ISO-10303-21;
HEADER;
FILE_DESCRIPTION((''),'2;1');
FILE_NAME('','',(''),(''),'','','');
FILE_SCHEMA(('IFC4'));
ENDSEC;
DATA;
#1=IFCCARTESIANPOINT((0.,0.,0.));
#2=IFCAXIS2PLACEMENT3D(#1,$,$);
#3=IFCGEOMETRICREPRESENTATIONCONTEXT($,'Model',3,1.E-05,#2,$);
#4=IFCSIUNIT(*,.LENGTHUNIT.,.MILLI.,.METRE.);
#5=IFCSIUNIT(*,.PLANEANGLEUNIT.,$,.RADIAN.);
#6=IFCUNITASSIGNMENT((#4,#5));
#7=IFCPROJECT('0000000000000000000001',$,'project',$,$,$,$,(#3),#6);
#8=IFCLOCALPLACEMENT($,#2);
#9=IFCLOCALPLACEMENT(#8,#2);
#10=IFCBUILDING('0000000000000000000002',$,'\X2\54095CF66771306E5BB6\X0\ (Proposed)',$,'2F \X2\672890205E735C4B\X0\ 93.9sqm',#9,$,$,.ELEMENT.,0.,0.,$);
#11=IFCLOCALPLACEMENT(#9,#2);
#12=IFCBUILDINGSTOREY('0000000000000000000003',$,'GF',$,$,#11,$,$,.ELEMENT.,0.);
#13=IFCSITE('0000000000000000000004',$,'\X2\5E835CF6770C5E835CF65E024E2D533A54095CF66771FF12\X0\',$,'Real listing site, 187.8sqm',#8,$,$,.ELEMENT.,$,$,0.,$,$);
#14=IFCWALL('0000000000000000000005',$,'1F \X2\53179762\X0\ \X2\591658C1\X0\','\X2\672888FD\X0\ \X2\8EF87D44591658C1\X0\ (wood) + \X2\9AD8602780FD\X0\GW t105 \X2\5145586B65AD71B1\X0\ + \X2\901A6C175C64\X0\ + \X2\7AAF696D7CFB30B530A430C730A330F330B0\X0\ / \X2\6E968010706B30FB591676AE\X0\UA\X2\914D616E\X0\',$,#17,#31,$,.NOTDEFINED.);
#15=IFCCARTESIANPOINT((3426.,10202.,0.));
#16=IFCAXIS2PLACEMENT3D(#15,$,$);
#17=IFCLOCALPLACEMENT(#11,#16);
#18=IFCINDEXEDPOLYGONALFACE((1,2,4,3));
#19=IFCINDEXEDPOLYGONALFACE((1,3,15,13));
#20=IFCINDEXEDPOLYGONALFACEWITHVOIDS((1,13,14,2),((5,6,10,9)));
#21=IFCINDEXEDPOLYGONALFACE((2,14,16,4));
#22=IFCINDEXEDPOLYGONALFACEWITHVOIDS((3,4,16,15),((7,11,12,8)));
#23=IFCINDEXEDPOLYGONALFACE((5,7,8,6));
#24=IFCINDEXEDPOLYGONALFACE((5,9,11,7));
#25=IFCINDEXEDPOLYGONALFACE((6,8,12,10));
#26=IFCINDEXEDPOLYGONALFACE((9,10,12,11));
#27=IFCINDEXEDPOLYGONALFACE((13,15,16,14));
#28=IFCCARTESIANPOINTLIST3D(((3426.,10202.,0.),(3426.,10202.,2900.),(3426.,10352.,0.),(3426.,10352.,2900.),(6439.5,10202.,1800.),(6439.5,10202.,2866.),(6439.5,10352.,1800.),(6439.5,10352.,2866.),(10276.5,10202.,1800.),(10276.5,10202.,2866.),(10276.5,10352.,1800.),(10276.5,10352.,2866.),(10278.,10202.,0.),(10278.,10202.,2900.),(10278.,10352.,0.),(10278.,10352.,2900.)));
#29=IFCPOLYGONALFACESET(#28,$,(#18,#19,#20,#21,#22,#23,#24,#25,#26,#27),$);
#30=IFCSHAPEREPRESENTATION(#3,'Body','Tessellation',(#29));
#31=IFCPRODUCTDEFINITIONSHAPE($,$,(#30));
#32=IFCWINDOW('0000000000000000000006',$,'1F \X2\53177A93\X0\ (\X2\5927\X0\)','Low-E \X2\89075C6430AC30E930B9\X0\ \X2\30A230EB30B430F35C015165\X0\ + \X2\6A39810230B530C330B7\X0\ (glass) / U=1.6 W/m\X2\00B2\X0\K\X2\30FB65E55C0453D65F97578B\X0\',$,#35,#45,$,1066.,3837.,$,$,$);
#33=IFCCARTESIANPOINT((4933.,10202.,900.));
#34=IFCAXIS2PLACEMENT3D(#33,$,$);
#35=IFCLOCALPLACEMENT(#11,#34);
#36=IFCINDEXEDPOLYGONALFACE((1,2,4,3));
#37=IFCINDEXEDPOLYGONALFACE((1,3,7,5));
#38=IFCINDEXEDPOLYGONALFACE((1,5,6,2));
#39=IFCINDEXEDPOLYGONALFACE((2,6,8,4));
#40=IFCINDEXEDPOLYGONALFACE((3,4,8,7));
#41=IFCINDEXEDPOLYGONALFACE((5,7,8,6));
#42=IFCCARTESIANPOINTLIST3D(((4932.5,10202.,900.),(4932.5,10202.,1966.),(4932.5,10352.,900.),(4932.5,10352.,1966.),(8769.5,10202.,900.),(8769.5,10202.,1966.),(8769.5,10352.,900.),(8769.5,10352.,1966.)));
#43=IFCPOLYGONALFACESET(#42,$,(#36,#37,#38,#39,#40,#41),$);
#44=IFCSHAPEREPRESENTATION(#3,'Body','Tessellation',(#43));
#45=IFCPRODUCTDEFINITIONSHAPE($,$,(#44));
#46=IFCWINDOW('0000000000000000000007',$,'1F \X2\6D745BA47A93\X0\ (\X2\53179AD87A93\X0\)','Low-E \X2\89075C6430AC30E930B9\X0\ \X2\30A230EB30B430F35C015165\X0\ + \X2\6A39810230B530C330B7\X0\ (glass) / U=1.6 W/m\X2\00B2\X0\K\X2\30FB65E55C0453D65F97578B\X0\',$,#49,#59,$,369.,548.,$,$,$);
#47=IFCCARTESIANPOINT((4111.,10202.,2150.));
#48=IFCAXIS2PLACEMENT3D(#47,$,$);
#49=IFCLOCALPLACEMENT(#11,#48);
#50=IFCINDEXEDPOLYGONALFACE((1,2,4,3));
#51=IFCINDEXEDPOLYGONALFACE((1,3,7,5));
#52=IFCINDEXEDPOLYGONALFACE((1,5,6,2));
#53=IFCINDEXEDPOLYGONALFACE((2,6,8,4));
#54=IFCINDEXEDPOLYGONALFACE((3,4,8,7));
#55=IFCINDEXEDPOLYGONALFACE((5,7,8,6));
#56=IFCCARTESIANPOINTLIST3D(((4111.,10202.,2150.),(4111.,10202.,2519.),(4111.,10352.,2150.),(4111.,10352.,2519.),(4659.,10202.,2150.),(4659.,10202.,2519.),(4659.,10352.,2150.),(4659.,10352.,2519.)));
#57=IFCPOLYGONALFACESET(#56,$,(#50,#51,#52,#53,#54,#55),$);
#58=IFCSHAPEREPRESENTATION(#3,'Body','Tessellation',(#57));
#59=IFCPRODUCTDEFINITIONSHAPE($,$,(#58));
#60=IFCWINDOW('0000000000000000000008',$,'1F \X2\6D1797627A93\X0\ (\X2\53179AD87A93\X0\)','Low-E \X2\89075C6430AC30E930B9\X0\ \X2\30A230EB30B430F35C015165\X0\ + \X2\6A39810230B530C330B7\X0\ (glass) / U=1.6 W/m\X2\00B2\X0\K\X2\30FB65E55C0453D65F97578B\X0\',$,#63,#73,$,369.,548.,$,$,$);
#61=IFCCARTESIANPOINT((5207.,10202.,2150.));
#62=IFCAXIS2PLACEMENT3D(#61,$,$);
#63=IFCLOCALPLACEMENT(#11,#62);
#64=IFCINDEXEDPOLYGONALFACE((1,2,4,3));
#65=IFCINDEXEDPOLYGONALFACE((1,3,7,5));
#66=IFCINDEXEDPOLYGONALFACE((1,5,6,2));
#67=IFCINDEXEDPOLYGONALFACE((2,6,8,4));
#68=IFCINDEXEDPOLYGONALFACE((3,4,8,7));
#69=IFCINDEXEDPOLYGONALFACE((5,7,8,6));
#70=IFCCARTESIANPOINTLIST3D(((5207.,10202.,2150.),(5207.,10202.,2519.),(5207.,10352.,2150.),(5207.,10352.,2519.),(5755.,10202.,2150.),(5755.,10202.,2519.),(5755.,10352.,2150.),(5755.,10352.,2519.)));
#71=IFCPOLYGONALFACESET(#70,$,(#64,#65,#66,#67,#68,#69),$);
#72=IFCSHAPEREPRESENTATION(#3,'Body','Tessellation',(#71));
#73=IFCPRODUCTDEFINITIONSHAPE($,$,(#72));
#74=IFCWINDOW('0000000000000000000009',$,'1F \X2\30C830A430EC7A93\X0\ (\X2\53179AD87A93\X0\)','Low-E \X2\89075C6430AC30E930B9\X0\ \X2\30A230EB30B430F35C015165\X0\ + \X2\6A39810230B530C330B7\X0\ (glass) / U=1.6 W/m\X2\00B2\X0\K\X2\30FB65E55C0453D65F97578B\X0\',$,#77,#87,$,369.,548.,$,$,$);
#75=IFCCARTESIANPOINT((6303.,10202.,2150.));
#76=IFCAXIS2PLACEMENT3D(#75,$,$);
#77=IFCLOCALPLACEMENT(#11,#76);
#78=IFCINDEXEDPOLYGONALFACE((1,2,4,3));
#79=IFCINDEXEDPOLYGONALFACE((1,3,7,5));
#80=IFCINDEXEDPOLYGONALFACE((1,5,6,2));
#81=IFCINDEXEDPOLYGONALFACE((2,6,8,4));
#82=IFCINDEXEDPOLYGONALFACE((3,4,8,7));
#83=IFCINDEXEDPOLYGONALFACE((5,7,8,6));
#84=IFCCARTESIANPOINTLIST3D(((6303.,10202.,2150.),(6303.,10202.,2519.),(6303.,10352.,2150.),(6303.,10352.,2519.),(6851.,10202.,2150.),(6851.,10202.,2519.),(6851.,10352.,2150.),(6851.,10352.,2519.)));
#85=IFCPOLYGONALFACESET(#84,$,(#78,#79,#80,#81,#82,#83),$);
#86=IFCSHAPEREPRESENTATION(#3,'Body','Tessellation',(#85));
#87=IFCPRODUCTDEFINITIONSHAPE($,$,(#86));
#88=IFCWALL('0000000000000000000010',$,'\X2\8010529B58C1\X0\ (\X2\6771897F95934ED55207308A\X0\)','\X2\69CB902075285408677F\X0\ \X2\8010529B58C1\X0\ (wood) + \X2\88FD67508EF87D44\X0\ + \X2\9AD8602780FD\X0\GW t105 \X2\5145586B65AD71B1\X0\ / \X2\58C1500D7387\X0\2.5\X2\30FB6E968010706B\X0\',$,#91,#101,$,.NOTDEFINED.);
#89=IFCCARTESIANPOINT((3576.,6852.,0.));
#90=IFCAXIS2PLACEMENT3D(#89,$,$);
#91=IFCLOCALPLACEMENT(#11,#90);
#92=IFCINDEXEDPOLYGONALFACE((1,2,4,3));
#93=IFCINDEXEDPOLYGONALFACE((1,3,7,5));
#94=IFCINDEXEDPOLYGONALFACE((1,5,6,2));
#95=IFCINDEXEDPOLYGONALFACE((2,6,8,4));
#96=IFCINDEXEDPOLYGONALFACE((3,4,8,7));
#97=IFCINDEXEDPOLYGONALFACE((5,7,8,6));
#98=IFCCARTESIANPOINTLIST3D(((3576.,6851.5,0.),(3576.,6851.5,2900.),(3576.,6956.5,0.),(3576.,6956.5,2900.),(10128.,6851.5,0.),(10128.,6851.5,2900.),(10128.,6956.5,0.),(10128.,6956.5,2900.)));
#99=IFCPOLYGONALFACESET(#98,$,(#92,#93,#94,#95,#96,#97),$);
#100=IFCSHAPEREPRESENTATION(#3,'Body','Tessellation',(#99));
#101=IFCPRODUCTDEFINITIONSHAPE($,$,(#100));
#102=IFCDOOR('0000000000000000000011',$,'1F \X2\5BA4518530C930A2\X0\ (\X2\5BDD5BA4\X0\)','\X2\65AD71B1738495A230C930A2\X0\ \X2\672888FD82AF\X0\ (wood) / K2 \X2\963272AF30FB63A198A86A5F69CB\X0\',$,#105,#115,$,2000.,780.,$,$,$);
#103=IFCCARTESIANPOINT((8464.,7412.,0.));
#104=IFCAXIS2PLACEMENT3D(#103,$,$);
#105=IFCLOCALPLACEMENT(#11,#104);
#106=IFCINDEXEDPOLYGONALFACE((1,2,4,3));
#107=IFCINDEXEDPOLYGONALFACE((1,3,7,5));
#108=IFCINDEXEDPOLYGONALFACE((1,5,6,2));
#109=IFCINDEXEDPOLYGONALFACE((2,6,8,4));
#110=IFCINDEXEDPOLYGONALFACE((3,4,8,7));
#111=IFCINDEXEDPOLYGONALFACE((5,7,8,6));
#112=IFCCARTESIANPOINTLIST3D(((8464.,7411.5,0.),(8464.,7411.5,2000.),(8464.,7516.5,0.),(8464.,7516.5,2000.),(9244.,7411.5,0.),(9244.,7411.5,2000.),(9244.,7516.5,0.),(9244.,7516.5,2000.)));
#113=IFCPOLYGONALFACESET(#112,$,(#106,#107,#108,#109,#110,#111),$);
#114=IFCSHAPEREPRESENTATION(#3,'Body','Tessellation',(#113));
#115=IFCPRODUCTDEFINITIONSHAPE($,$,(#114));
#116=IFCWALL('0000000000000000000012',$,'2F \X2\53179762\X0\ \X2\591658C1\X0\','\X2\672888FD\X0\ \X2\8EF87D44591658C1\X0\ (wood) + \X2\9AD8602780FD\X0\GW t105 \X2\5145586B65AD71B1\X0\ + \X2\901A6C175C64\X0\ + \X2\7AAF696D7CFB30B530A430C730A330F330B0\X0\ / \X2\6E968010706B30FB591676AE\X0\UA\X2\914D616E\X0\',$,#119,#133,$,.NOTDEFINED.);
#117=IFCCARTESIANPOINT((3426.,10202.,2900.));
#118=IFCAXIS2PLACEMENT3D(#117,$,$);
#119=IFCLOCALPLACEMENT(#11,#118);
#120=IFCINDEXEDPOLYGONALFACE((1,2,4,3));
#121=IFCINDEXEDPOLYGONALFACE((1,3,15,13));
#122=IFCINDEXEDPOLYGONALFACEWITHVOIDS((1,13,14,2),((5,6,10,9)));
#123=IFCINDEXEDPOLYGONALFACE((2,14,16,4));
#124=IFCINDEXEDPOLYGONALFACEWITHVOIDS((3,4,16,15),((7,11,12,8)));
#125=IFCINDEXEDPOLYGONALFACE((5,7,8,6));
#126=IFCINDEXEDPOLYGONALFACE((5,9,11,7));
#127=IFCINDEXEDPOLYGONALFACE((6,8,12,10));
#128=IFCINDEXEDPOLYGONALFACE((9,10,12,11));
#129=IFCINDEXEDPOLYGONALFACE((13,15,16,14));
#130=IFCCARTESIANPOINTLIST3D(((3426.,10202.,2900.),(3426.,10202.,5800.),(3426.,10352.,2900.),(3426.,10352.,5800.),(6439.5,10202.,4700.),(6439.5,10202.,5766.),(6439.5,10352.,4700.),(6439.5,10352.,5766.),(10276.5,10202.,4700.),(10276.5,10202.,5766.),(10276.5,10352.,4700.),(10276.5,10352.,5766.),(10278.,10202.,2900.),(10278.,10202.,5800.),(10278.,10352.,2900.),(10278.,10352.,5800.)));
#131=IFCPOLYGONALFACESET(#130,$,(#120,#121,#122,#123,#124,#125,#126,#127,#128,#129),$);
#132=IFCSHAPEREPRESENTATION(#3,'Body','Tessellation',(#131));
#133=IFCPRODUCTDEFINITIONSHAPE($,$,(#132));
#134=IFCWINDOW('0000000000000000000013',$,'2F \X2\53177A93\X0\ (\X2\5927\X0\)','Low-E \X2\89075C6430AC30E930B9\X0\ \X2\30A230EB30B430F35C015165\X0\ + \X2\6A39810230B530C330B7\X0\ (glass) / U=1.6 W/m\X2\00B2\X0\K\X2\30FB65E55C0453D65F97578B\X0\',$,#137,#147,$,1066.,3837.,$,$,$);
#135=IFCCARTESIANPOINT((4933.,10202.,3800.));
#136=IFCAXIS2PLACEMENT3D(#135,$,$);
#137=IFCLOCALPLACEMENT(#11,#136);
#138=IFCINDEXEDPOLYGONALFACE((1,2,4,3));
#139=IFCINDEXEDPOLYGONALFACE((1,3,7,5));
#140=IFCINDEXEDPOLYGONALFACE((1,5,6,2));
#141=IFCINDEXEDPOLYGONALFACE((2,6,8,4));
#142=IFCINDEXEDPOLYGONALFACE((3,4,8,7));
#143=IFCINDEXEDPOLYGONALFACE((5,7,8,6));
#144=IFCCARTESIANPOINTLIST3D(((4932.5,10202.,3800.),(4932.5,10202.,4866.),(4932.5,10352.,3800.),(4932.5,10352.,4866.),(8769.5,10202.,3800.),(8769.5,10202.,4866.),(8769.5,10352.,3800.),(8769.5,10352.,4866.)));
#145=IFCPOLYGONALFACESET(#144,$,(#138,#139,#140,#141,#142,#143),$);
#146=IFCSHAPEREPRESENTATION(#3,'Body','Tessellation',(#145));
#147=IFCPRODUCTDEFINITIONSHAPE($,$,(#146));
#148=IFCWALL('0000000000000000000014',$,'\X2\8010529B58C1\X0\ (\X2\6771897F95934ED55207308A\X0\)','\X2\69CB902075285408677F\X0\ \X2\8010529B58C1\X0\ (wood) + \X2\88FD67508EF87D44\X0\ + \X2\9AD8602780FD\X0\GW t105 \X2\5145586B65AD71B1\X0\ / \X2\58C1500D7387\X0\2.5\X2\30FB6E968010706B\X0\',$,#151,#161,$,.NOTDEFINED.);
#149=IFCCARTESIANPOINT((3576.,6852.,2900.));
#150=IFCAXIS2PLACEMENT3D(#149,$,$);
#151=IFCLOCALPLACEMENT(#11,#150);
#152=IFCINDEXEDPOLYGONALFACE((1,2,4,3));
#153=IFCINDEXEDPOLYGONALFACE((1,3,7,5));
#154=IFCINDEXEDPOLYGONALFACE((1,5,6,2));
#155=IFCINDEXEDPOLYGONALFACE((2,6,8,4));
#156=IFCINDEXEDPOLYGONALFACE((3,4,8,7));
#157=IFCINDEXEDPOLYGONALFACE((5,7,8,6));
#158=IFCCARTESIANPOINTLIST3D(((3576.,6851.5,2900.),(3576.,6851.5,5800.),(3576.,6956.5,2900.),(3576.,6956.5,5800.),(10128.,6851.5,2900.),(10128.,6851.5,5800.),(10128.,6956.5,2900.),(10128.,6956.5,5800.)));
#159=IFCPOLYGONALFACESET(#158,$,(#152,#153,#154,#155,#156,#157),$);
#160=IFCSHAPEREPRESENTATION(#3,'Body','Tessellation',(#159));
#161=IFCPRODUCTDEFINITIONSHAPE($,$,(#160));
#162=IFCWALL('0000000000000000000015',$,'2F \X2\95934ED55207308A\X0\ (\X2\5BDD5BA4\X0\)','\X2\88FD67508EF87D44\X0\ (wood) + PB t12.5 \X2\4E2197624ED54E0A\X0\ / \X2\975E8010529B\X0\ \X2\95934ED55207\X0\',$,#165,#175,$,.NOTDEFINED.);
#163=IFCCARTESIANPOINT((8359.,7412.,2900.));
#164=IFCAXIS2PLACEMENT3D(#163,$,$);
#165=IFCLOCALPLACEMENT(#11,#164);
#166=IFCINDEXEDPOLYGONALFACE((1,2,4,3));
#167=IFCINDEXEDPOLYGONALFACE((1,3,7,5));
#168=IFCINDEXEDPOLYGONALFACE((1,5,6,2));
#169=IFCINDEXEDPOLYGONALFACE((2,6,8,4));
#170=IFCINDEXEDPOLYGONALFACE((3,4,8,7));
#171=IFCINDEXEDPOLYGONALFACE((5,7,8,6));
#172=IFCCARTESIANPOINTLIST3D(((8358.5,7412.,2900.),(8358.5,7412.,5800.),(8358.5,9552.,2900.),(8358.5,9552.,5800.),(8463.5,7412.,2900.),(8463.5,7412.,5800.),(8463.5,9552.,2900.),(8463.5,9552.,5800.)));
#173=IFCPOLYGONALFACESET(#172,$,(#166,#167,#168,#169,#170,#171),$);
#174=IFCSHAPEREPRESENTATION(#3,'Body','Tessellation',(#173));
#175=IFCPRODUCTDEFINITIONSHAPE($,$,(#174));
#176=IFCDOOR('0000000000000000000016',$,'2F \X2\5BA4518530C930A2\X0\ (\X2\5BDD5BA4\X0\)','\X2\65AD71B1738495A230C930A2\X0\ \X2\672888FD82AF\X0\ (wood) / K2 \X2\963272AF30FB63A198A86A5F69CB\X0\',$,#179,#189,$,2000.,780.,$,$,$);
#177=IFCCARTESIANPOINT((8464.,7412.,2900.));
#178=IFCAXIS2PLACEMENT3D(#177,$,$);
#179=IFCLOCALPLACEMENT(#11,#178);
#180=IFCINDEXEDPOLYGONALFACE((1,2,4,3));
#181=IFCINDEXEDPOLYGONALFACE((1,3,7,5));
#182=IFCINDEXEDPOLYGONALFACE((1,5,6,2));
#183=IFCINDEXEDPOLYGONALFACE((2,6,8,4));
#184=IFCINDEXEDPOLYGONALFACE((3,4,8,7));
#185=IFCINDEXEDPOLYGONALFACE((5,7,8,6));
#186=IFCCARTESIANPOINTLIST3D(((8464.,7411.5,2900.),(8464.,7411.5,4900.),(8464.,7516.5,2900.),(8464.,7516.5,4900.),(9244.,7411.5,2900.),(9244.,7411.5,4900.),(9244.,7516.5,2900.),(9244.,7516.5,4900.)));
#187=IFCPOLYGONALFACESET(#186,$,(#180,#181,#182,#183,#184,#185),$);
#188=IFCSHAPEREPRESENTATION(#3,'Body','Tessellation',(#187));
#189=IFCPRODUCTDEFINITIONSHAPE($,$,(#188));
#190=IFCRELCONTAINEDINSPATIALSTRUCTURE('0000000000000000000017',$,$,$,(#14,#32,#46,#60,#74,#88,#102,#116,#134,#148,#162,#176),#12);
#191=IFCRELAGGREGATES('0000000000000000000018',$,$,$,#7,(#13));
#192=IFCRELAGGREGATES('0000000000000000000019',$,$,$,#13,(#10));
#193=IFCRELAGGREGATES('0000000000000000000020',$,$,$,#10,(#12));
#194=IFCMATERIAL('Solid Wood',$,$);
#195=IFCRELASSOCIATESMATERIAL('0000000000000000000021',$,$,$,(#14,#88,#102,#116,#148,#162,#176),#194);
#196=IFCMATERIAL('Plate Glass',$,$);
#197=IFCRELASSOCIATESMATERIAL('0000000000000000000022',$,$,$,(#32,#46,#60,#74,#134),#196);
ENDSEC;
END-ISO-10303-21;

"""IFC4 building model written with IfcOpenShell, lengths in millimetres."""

from ifc_helpers import new_model, si_unit, frame, frame_2d, origin, place, context, project, spatial, rectangle, extrude, material, element, fill, save


model = new_model("IFC4")

# Units and contexts
model_context = context("Model", 3, precision=1e-05, world=origin())
ifc_project = project(units=[si_unit("LENGTHUNIT", "METRE", prefix="MILLI"), si_unit("PLANEANGLEUNIT", "RADIAN")], contexts=[model_context])

# Site, building, storey
site_placement = place(None, origin())
site = spatial("IfcSite", under=ifc_project, at=site_placement, Name="広島県広島市中区吉島東２", ObjectType="Real listing site, 187.8sqm", CompositionType="ELEMENT", RefElevation=0.0)
building_placement = place(site_placement, origin())
building = spatial("IfcBuilding", under=site, at=building_placement, Name="吉島東の家 (Proposed)", ObjectType="2F 木造平屋 93.9sqm", CompositionType="ELEMENT", ElevationOfRefHeight=0.0, ElevationOfTerrain=0.0)
storey_placement = place(building_placement, origin())
storey = spatial("IfcBuildingStorey", under=building, at=storey_placement, Name="GF", CompositionType="ELEMENT", Elevation=0.0)

# Wall, openings, windows
ifc_material_1 = material(Name="Solid Wood")
wall_1_placement = place(storey_placement, frame((3426.0, 10202.0, 0.0)))
wall_1 = element("IfcWall", 1, at=wall_1_placement, inside=storey, material=ifc_material_1, Name="1F 北面 外壁", Description="木製 軸組外壁 (wood) + 高性能GW t105 充填断熱 + 通気層 + 窯業系サイディング / 準耐火・外皮UA配慮", PredefinedType="NOTDEFINED", context=model_context, shape_type="SweptSolid", body=[
    extrude(rectangle(XDim=6852.0, YDim=150.0, at=frame_2d((3426.0, 75.0))), frame((3426.0, 10202.0, 0.0)), (0.0, 0.0, 1.0), 2900.0),
])
opening_1_placement = place(storey_placement, frame((4933.0, 10202.0, 900.0)))
opening_1 = element("IfcOpeningElement", 2, at=opening_1_placement, cuts=wall_1, PredefinedType="NOTDEFINED", context=model_context, shape_type="SweptSolid", body=[
    extrude(rectangle(XDim=3837.0, YDim=150.0, at=frame_2d((1918.0, 75.0))), frame((4933.0, 10202.0, 900.0)), (0.0, 0.0, 1.0), 1066.0),
])
opening_2_placement = place(storey_placement, frame((4111.0, 10202.0, 2150.0)))
opening_2 = element("IfcOpeningElement", 3, at=opening_2_placement, cuts=wall_1, PredefinedType="NOTDEFINED", context=model_context, shape_type="SweptSolid", body=[
    extrude(rectangle(XDim=548.0, YDim=150.0, at=frame_2d((274.0, 75.0))), frame((4111.0, 10202.0, 2150.0)), (0.0, 0.0, 1.0), 369.0),
])
opening_3_placement = place(storey_placement, frame((5207.0, 10202.0, 2150.0)))
opening_3 = element("IfcOpeningElement", 4, at=opening_3_placement, cuts=wall_1, PredefinedType="NOTDEFINED", context=model_context, shape_type="SweptSolid", body=[
    extrude(rectangle(XDim=548.0, YDim=150.0, at=frame_2d((274.0, 75.0))), frame((5207.0, 10202.0, 2150.0)), (0.0, 0.0, 1.0), 369.0),
])
opening_4_placement = place(storey_placement, frame((6303.0, 10202.0, 2150.0)))
opening_4 = element("IfcOpeningElement", 5, at=opening_4_placement, cuts=wall_1, PredefinedType="NOTDEFINED", context=model_context, shape_type="SweptSolid", body=[
    extrude(rectangle(XDim=548.0, YDim=150.0, at=frame_2d((274.0, 75.0))), frame((6303.0, 10202.0, 2150.0)), (0.0, 0.0, 1.0), 369.0),
])
ifc_material_2 = material(Name="Plate Glass")
window_1_placement = place(storey_placement, frame((4933.0, 10202.0, 900.0)))
window_1 = element("IfcWindow", 6, at=window_1_placement, inside=storey, material=ifc_material_2, Name="1F 北窓 (大)", Description="Low-E 複層ガラス アルゴン封入 + 樹脂サッシ (glass) / U=1.6 W/m²K・日射取得型", OverallHeight=1066.0, OverallWidth=3837.0, context=model_context, shape_type="SweptSolid", body=[
    extrude(rectangle(XDim=3837.0, YDim=150.0, at=frame_2d((1918.0, 75.0))), frame((4933.0, 10202.0, 900.0)), (0.0, 0.0, 1.0), 1066.0),
])
fill(opening_1, window_1)
window_2_placement = place(storey_placement, frame((4111.0, 10202.0, 2150.0)))
window_2 = element("IfcWindow", 7, at=window_2_placement, inside=storey, material=ifc_material_2, Name="1F 浴室窓 (北高窓)", Description="Low-E 複層ガラス アルゴン封入 + 樹脂サッシ (glass) / U=1.6 W/m²K・日射取得型", OverallHeight=369.0, OverallWidth=548.0, context=model_context, shape_type="SweptSolid", body=[
    extrude(rectangle(XDim=548.0, YDim=150.0, at=frame_2d((274.0, 75.0))), frame((4111.0, 10202.0, 2150.0)), (0.0, 0.0, 1.0), 369.0),
])
fill(opening_2, window_2)
window_3_placement = place(storey_placement, frame((5207.0, 10202.0, 2150.0)))
window_3 = element("IfcWindow", 8, at=window_3_placement, inside=storey, material=ifc_material_2, Name="1F 洗面窓 (北高窓)", Description="Low-E 複層ガラス アルゴン封入 + 樹脂サッシ (glass) / U=1.6 W/m²K・日射取得型", OverallHeight=369.0, OverallWidth=548.0, context=model_context, shape_type="SweptSolid", body=[
    extrude(rectangle(XDim=548.0, YDim=150.0, at=frame_2d((274.0, 75.0))), frame((5207.0, 10202.0, 2150.0)), (0.0, 0.0, 1.0), 369.0),
])
fill(opening_3, window_3)
window_4_placement = place(storey_placement, frame((6303.0, 10202.0, 2150.0)))
window_4 = element("IfcWindow", 9, at=window_4_placement, inside=storey, material=ifc_material_2, Name="1F トイレ窓 (北高窓)", Description="Low-E 複層ガラス アルゴン封入 + 樹脂サッシ (glass) / U=1.6 W/m²K・日射取得型", OverallHeight=369.0, OverallWidth=548.0, context=model_context, shape_type="SweptSolid", body=[
    extrude(rectangle(XDim=548.0, YDim=150.0, at=frame_2d((274.0, 75.0))), frame((6303.0, 10202.0, 2150.0)), (0.0, 0.0, 1.0), 369.0),
])
fill(opening_4, window_4)

# Wall
wall_2_placement = place(storey_placement, frame((3576.0, 6852.0, 0.0)))
element("IfcWall", 10, at=wall_2_placement, inside=storey, material=ifc_material_1, Name="耐力壁 (東西間仕切り)", Description="構造用合板 耐力壁 (wood) + 製材軸組 + 高性能GW t105 充填断熱 / 壁倍率2.5・準耐火", PredefinedType="NOTDEFINED", context=model_context, shape_type="SweptSolid", body=[
    extrude(rectangle(XDim=6552.0, YDim=105.0, at=frame_2d((3276.0, 52.0))), frame((3576.0, 6852.0, 0.0)), (0.0, 0.0, 1.0), 2900.0),
])

# Door
door_1_placement = place(storey_placement, frame((8464.0, 7412.0, 0.0)))
element("IfcDoor", 11, at=door_1_placement, inside=storey, material=ifc_material_1, Name="1F 室内ドア (寝室)", Description="断熱玄関ドア 木製芯 (wood) / K2 防犯・採風機構", OverallHeight=2000.0, OverallWidth=780.0, context=model_context, shape_type="SweptSolid", body=[
    extrude(rectangle(XDim=780.0, YDim=105.0, at=frame_2d((390.0, 52.0))), frame((8464.0, 7412.0, 0.0)), (0.0, 0.0, 1.0), 2000.0),
])

# Wall, opening, window
wall_3_placement = place(storey_placement, frame((3426.0, 10202.0, 2900.0)))
wall_3 = element("IfcWall", 12, at=wall_3_placement, inside=storey, material=ifc_material_1, Name="2F 北面 外壁", Description="木製 軸組外壁 (wood) + 高性能GW t105 充填断熱 + 通気層 + 窯業系サイディング / 準耐火・外皮UA配慮", PredefinedType="NOTDEFINED", context=model_context, shape_type="SweptSolid", body=[
    extrude(rectangle(XDim=6852.0, YDim=150.0, at=frame_2d((3426.0, 75.0))), frame((3426.0, 10202.0, 2900.0)), (0.0, 0.0, 1.0), 2900.0),
])
opening_5_placement = place(storey_placement, frame((4933.0, 10202.0, 3800.0)))
opening_5 = element("IfcOpeningElement", 13, at=opening_5_placement, cuts=wall_3, PredefinedType="NOTDEFINED", context=model_context, shape_type="SweptSolid", body=[
    extrude(rectangle(XDim=3837.0, YDim=150.0, at=frame_2d((1918.0, 75.0))), frame((4933.0, 10202.0, 3800.0)), (0.0, 0.0, 1.0), 1066.0),
])
window_5_placement = place(storey_placement, frame((4933.0, 10202.0, 3800.0)))
window_5 = element("IfcWindow", 14, at=window_5_placement, inside=storey, material=ifc_material_2, Name="2F 北窓 (大)", Description="Low-E 複層ガラス アルゴン封入 + 樹脂サッシ (glass) / U=1.6 W/m²K・日射取得型", OverallHeight=1066.0, OverallWidth=3837.0, context=model_context, shape_type="SweptSolid", body=[
    extrude(rectangle(XDim=3837.0, YDim=150.0, at=frame_2d((1918.0, 75.0))), frame((4933.0, 10202.0, 3800.0)), (0.0, 0.0, 1.0), 1066.0),
])
fill(opening_5, window_5)

# Walls
wall_4_placement = place(storey_placement, frame((3576.0, 6852.0, 2900.0)))
element("IfcWall", 15, at=wall_4_placement, inside=storey, material=ifc_material_1, Name="耐力壁 (東西間仕切り)", Description="構造用合板 耐力壁 (wood) + 製材軸組 + 高性能GW t105 充填断熱 / 壁倍率2.5・準耐火", PredefinedType="NOTDEFINED", context=model_context, shape_type="SweptSolid", body=[
    extrude(rectangle(XDim=6552.0, YDim=105.0, at=frame_2d((3276.0, 52.0))), frame((3576.0, 6852.0, 2900.0)), (0.0, 0.0, 1.0), 2900.0),
])
wall_5_placement = place(storey_placement, frame((8359.0, 7412.0, 2900.0)))
element("IfcWall", 16, at=wall_5_placement, inside=storey, material=ifc_material_1, Name="2F 間仕切り (寝室)", Description="製材軸組 (wood) + PB t12.5 両面仕上 / 非耐力 間仕切", PredefinedType="NOTDEFINED", context=model_context, shape_type="SweptSolid", body=[
    extrude(rectangle(XDim=105.0, YDim=2140.0, at=frame_2d((52.0, 1070.0))), frame((8359.0, 7412.0, 2900.0)), (0.0, 0.0, 1.0), 2900.0),
])

# Door
door_2_placement = place(storey_placement, frame((8464.0, 7412.0, 2900.0)))
element("IfcDoor", 17, at=door_2_placement, inside=storey, material=ifc_material_1, Name="2F 室内ドア (寝室)", Description="断熱玄関ドア 木製芯 (wood) / K2 防犯・採風機構", OverallHeight=2000.0, OverallWidth=780.0, context=model_context, shape_type="SweptSolid", body=[
    extrude(rectangle(XDim=780.0, YDim=105.0, at=frame_2d((390.0, 52.0))), frame((8464.0, 7412.0, 2900.0)), (0.0, 0.0, 1.0), 2000.0),
])

save(model, "model.ifc")
